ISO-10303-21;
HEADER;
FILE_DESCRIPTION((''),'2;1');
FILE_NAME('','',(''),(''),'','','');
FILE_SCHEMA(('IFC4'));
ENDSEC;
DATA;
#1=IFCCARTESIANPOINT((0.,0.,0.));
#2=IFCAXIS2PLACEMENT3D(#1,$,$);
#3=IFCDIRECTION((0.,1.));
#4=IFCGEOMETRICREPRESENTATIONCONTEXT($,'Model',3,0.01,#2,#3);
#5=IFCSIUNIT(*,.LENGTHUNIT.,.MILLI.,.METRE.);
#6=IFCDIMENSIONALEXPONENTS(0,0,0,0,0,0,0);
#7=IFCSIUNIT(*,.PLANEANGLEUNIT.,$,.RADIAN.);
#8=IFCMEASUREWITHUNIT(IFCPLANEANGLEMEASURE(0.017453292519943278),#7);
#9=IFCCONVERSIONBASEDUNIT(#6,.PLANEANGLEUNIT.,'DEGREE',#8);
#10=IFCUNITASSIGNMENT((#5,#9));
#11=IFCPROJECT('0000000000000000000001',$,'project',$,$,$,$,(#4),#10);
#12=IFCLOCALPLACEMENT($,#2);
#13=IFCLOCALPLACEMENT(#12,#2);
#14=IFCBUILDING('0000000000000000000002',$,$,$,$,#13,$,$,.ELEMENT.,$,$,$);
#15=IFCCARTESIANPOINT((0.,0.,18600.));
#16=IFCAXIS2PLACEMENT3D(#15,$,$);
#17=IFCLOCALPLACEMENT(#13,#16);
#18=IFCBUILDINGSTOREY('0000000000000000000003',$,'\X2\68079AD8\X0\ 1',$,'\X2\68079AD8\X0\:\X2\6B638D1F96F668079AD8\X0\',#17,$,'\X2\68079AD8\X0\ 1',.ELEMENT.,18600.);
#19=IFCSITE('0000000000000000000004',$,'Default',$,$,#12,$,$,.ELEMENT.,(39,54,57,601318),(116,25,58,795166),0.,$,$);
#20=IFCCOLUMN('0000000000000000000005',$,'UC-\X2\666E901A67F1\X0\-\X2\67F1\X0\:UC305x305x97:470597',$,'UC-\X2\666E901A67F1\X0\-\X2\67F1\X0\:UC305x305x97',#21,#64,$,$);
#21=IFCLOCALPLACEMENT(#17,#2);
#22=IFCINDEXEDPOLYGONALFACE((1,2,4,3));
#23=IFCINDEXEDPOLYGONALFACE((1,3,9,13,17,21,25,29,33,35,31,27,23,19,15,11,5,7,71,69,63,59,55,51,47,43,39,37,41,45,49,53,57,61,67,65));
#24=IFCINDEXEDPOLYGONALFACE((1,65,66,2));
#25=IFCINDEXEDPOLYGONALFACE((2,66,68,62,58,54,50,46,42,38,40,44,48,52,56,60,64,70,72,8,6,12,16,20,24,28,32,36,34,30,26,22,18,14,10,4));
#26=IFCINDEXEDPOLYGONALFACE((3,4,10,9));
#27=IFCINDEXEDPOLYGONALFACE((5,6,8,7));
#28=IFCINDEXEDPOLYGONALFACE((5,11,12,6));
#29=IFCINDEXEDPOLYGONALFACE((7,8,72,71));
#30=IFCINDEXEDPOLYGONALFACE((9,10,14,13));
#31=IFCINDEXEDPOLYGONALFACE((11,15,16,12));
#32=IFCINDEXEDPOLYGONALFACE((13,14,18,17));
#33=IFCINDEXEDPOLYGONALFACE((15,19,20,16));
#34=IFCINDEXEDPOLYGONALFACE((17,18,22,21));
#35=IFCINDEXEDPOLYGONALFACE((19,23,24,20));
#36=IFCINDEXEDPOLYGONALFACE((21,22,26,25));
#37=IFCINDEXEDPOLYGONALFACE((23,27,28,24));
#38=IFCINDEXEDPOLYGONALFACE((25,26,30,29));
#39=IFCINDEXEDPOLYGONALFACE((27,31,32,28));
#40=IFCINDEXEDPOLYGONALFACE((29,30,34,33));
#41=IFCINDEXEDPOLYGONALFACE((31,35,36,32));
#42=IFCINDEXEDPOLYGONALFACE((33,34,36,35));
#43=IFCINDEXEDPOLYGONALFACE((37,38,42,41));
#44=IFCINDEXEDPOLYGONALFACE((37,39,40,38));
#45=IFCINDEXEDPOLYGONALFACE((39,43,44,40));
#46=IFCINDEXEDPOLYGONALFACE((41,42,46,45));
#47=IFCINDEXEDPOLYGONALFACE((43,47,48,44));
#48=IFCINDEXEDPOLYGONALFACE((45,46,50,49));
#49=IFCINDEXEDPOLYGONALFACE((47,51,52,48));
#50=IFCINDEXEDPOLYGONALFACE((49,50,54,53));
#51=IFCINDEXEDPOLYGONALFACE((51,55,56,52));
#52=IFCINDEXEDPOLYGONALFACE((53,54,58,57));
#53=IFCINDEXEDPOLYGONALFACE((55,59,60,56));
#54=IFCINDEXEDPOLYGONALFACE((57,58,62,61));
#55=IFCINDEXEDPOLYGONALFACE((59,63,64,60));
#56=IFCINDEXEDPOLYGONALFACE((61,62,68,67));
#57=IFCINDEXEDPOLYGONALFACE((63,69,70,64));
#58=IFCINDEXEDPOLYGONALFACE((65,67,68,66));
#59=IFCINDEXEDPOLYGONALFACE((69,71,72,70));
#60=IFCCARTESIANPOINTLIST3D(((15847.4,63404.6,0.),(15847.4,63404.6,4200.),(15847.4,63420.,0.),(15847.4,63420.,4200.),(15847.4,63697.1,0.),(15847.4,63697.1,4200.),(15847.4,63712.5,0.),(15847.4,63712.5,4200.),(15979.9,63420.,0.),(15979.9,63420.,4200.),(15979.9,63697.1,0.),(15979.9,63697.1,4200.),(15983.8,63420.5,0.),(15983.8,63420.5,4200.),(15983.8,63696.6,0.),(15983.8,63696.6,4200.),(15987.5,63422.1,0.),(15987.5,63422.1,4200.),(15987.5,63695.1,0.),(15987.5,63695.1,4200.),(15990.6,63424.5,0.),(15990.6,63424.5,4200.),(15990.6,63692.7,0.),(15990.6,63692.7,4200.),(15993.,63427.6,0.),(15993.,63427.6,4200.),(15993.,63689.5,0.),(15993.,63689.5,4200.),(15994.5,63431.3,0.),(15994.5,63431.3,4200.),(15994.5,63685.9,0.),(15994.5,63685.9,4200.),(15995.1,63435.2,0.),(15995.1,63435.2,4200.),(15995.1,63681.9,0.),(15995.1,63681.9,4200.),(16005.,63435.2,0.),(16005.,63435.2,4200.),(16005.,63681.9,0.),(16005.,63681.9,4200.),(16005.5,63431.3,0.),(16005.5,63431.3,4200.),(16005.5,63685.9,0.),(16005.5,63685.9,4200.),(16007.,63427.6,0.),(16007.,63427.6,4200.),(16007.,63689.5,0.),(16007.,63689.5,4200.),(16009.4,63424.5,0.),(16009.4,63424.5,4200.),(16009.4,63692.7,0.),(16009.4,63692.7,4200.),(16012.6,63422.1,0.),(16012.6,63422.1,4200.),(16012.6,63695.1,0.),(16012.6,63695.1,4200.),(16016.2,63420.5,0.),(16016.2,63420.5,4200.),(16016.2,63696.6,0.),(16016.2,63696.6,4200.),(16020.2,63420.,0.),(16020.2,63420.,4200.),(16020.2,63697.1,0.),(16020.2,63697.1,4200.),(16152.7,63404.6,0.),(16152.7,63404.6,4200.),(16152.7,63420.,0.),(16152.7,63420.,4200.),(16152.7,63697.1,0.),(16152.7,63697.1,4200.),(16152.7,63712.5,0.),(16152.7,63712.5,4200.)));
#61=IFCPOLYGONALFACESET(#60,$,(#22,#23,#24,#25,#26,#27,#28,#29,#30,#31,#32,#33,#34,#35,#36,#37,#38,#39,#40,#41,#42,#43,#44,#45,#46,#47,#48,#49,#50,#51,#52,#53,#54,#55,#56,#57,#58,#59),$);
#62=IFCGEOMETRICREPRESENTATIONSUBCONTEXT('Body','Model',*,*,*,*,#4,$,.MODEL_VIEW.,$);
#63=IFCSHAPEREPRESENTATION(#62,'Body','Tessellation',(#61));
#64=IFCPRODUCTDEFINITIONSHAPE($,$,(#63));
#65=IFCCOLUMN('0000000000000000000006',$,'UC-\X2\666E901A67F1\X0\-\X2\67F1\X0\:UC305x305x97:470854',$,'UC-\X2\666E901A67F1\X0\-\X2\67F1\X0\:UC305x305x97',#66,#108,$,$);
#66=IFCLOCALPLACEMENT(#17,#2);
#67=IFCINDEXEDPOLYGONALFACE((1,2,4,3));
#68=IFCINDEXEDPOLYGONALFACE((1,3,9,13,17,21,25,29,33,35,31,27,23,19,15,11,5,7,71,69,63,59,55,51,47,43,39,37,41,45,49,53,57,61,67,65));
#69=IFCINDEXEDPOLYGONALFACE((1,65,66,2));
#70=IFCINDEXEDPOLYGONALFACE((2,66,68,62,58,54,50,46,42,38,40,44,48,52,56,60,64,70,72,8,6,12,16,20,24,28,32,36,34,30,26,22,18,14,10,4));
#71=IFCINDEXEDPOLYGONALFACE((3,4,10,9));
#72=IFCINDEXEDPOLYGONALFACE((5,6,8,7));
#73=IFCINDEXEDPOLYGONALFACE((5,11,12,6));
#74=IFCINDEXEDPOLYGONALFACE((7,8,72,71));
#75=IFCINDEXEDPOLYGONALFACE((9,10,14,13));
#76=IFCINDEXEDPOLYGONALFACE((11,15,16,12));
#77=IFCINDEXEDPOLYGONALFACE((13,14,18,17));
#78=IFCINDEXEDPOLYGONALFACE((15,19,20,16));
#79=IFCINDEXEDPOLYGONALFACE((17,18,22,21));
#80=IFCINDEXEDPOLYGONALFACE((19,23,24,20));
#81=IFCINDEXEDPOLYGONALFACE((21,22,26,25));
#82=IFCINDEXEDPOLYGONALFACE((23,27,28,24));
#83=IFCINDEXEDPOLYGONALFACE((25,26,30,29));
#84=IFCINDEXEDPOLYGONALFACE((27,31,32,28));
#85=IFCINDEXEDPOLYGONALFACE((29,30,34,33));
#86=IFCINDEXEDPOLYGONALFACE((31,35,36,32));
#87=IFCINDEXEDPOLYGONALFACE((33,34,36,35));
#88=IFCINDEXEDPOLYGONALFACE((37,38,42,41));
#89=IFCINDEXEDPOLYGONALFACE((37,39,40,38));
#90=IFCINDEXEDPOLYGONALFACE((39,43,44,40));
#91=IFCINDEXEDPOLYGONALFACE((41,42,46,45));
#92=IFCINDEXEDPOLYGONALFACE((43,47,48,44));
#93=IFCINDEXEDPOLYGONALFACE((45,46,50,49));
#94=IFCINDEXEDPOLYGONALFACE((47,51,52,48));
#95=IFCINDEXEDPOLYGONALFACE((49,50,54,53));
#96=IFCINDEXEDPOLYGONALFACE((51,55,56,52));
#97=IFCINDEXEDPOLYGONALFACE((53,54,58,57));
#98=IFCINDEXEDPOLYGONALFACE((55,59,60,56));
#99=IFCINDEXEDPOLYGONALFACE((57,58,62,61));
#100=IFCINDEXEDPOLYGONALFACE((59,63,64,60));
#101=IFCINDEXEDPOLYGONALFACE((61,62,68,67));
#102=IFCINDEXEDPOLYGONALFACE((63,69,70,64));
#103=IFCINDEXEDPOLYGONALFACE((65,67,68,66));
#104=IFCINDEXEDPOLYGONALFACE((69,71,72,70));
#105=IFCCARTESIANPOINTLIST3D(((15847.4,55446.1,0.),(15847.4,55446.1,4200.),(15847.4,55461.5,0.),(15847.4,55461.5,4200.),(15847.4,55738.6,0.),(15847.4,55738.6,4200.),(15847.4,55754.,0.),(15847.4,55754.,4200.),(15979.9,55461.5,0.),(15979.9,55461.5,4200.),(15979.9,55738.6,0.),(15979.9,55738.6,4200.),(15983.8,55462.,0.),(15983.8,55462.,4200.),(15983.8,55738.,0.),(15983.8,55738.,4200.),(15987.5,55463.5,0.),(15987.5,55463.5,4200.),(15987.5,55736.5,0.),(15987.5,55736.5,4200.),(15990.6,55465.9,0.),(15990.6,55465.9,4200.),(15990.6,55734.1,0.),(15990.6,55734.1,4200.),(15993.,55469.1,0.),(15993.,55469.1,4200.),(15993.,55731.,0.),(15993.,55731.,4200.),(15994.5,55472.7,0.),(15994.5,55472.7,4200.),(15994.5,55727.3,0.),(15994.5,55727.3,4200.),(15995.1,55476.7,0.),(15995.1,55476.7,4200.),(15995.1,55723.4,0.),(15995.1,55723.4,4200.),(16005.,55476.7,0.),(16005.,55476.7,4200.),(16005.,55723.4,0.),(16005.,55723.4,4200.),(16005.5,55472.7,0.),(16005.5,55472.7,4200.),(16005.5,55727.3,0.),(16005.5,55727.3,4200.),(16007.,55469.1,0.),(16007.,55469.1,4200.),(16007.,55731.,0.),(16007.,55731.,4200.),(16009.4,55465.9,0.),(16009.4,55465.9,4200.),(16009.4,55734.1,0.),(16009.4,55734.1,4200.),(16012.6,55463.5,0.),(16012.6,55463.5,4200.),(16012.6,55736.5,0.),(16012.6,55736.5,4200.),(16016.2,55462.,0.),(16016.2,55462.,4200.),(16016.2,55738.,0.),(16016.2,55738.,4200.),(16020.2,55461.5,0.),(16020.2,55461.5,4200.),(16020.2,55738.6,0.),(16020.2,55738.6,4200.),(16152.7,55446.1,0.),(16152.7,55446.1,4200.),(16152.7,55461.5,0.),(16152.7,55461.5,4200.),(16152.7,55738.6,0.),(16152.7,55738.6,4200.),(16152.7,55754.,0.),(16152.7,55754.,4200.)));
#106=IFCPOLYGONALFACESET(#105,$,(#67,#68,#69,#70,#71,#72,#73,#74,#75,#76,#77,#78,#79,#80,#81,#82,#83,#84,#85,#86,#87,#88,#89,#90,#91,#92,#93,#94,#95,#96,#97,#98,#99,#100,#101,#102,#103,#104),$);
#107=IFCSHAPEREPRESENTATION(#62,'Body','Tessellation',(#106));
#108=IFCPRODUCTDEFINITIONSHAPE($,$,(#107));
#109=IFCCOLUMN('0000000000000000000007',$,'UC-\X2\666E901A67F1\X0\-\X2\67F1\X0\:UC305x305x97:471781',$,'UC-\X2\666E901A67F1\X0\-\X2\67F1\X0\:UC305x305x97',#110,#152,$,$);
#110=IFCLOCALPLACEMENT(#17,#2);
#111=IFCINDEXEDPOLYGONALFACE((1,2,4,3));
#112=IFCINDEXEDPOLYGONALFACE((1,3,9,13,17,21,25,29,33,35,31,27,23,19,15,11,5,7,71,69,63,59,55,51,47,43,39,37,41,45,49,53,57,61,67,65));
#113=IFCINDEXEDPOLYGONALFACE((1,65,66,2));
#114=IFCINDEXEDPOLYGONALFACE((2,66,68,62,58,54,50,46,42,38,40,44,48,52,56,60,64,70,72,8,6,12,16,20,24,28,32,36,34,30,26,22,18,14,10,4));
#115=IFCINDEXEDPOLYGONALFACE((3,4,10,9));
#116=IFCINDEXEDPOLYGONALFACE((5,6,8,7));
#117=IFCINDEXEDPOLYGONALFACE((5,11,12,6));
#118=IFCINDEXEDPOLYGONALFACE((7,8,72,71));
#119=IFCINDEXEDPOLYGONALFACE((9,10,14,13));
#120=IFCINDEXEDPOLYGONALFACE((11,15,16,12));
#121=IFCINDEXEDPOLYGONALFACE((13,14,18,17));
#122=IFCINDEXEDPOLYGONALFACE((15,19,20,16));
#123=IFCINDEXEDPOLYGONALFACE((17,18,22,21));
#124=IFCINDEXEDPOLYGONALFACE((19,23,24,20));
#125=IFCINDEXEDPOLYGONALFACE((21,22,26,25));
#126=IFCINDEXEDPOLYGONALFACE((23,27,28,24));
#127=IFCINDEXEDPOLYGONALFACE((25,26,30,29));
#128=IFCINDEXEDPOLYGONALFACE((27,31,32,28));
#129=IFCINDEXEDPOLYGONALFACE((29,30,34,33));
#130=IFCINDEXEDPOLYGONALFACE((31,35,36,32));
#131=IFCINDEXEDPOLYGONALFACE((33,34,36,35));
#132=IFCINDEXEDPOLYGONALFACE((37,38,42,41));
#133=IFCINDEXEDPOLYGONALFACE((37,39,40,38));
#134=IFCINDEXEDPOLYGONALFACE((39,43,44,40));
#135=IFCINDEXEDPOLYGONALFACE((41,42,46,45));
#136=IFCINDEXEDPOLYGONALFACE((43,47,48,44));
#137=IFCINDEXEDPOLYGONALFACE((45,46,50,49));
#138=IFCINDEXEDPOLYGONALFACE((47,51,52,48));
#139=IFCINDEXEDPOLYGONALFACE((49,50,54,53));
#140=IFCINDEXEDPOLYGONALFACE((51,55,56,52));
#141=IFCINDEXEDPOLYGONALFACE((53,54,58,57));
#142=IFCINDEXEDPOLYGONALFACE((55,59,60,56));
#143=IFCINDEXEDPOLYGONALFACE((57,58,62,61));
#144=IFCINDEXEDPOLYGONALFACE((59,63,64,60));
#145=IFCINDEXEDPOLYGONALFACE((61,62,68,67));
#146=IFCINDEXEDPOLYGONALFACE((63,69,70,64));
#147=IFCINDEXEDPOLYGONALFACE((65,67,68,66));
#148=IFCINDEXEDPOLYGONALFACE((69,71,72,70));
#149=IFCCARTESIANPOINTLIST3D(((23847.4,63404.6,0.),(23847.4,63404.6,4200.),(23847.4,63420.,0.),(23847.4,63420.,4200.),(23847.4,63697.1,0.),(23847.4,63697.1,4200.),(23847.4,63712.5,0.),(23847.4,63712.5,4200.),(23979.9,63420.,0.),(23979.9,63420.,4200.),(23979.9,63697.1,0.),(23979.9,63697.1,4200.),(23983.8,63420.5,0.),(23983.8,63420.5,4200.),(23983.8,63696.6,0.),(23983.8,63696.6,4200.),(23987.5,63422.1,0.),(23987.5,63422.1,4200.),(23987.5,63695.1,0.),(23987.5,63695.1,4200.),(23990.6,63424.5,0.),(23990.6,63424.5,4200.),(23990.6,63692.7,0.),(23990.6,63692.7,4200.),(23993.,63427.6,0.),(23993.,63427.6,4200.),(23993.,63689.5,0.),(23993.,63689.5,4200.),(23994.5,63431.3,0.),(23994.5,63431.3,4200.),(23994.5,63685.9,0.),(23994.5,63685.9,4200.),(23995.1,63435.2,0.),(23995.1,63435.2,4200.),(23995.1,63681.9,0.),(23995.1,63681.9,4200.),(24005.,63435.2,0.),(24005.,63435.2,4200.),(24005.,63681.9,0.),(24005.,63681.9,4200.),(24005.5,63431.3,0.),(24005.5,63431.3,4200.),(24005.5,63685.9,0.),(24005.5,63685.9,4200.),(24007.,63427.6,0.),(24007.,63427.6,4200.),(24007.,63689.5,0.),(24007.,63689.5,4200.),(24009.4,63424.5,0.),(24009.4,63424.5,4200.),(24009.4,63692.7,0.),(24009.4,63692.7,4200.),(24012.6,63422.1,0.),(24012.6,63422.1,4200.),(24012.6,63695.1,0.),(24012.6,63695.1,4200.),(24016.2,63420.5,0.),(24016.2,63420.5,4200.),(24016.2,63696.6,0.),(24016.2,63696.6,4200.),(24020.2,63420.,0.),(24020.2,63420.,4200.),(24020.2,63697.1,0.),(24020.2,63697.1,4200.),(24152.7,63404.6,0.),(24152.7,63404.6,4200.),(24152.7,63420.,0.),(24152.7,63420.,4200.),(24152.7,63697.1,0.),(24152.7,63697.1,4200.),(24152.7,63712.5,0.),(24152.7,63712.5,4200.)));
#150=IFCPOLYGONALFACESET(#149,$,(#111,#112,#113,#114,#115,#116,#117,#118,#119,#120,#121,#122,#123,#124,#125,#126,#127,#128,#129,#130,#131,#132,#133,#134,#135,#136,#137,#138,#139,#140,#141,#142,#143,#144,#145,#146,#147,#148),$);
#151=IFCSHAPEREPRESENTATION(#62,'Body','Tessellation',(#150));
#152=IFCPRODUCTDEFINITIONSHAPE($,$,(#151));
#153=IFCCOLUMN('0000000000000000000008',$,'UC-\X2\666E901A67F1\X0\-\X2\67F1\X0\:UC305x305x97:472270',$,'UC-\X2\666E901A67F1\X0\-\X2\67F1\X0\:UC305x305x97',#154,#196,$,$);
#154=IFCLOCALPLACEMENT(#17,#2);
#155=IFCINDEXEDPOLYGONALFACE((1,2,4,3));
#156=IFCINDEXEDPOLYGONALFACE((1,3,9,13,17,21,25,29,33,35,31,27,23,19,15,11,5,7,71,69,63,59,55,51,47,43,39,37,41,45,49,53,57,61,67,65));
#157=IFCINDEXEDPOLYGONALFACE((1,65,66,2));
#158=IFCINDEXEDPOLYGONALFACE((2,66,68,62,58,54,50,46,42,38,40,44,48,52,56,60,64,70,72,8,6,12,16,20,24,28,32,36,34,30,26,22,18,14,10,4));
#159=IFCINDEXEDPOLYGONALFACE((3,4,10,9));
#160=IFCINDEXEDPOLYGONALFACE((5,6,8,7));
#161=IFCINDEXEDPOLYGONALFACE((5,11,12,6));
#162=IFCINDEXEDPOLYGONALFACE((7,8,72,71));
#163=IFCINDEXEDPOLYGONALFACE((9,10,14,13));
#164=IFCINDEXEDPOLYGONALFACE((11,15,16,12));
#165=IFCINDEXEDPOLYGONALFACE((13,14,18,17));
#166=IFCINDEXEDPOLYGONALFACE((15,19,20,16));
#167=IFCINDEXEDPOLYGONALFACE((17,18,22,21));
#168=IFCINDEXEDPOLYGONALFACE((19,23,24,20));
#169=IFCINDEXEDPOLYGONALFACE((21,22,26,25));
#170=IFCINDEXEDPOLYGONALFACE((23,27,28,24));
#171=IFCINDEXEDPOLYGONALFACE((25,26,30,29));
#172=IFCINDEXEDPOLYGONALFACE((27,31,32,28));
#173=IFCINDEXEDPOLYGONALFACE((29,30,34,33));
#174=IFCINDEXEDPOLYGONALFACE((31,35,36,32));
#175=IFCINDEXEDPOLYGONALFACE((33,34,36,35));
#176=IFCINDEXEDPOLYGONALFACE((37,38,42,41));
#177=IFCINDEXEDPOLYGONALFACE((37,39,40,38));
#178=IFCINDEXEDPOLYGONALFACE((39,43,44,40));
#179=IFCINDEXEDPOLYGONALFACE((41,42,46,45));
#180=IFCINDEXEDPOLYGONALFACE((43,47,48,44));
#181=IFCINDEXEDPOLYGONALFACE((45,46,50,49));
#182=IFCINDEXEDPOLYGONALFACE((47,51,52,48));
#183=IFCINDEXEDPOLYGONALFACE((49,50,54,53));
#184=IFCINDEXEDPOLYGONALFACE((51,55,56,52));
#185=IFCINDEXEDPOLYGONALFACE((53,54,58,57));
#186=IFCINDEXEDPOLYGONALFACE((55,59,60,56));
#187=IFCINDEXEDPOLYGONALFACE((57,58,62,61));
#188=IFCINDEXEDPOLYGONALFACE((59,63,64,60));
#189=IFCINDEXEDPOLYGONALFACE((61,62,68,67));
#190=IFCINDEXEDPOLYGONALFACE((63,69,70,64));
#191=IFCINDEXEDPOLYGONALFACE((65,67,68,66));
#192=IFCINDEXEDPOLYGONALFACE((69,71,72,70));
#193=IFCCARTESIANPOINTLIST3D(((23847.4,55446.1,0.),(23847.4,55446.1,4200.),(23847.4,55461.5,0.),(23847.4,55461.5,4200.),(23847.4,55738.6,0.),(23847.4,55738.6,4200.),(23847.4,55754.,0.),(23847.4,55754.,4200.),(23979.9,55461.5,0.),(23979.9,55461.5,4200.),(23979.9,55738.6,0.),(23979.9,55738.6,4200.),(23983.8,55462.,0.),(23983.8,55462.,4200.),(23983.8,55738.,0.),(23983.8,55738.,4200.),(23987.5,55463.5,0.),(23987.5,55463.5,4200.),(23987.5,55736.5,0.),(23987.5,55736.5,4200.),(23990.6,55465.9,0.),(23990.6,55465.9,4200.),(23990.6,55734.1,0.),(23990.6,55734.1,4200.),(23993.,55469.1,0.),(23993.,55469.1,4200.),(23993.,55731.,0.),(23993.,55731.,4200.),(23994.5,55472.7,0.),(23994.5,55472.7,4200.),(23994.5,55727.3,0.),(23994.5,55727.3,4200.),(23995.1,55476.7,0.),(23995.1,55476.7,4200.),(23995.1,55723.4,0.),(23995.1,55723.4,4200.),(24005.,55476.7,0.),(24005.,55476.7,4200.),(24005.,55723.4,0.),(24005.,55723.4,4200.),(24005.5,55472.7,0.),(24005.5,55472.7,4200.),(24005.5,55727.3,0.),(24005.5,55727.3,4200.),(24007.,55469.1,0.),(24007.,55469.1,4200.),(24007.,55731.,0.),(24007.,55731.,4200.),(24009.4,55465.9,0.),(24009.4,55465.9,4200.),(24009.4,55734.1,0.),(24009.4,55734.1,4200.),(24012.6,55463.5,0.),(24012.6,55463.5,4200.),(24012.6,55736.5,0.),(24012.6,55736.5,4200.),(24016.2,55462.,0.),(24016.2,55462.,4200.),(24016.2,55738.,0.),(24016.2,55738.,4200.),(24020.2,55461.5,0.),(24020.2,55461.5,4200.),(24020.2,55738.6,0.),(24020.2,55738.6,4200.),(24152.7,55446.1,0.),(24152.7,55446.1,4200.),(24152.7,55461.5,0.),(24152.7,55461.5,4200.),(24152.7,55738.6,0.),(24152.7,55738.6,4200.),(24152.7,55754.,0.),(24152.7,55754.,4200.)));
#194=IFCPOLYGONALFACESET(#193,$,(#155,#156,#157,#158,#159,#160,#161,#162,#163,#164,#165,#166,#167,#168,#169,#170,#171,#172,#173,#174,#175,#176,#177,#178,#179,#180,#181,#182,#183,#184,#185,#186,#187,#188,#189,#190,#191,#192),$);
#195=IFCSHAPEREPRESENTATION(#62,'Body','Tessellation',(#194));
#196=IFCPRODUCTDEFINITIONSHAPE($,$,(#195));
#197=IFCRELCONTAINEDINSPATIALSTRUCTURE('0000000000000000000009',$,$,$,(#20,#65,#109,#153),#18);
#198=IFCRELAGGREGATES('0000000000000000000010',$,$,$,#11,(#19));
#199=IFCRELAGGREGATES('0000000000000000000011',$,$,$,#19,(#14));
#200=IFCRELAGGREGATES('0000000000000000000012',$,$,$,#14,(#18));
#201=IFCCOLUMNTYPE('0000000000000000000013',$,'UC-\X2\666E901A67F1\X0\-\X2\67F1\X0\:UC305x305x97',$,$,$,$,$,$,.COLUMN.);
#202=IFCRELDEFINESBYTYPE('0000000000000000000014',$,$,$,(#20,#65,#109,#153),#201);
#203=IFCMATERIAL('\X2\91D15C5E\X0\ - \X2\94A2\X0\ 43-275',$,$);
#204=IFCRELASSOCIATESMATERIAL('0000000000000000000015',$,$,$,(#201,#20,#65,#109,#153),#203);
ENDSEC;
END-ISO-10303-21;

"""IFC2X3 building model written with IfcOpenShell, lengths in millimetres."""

from ifc_helpers import new_model, entity, si_unit, converted_unit, direction, frame, origin, origin_2d_with_axis, place, context, subcontext, project, spatial, i_section, extrude, source, transform, mapped, material, type_object, type_shapes, element, save


model = new_model("IFC2X3")

# Units and contexts
model_context = context("Model", 3, precision=0.01, world=origin(), true_north=direction((0.0, 1.0)))
body_context = subcontext(model_context, "Body", "Model", "MODEL_VIEW")
ifc_project = project(units=[si_unit("LENGTHUNIT", "METRE", prefix="MILLI"), converted_unit("PLANEANGLEUNIT", "DEGREE", entity("IfcPlaneAngleMeasure", 0.017453292519943278), si_unit("PLANEANGLEUNIT", "RADIAN"), dimensions=[0, 0, 0, 0, 0, 0, 0])], contexts=[model_context])

# Site, building, storey
site_placement = place(None, origin())
site = spatial("IfcSite", under=ifc_project, at=site_placement, Name="Default", CompositionType="ELEMENT", RefLatitude=(39, 54, 57, 601318), RefLongitude=(116, 25, 58, 795166), RefElevation=0.0)
building_placement = place(site_placement, origin())
building = spatial("IfcBuilding", under=site, at=building_placement, CompositionType="ELEMENT")
storey_placement = place(building_placement, frame((0.0, 0.0, 18600.0)))
storey = spatial("IfcBuildingStorey", under=building, at=storey_placement, Name="标高 1", ObjectType="标高:正负零标高", LongName="标高 1", CompositionType="ELEMENT", Elevation=18600.0)

# Columns
ifc_material_1 = material(Name="金属 - 钢 43-275")
column_type = type_object("IfcColumnType", Name="UC-普通柱-柱:UC305x305x97", PredefinedType="COLUMN", material=ifc_material_1)
shared_shape_1 = source(origin(), body_context, "Body", "SweptSolid", [
    extrude(i_section(OverallWidth=305.3, OverallDepth=307.9, WebThickness=9.9, FlangeThickness=15.4, FilletRadius=15.2, at=origin_2d_with_axis()), frame((0.0, 0.0, 18600.0), z_axis=(0.0, 0.0, 1.0), x_axis=(-1.0, 0.0, 0.0)), (0.0, 0.0, 1.0), 4200.0),
])
type_shapes(column_type, [shared_shape_1])
for number, where, name in (
    (1, (16000.0, 63558.6, -18600.0), "UC-普通柱-柱:UC305x305x97:470597"),
    (2, (16000.0, 55600.0, -18600.0), "UC-普通柱-柱:UC305x305x97:470854"),
    (3, (24000.0, 63558.6, -18600.0), "UC-普通柱-柱:UC305x305x97:471781"),
    (4, (24000.0, 55600.0, -18600.0), "UC-普通柱-柱:UC305x305x97:472270"),
):
    element("IfcColumn", number, at=place(storey_placement, frame(where)), inside=storey, type_object=column_type, material=ifc_material_1, Name=name, ObjectType="UC-普通柱-柱:UC305x305x97", context=body_context, shape_type="MappedRepresentation", body=[
        mapped(shared_shape_1, transform((0.0, 0.0, 0.0), scale=1.0)),
    ])

save(model, "model.ifc")
